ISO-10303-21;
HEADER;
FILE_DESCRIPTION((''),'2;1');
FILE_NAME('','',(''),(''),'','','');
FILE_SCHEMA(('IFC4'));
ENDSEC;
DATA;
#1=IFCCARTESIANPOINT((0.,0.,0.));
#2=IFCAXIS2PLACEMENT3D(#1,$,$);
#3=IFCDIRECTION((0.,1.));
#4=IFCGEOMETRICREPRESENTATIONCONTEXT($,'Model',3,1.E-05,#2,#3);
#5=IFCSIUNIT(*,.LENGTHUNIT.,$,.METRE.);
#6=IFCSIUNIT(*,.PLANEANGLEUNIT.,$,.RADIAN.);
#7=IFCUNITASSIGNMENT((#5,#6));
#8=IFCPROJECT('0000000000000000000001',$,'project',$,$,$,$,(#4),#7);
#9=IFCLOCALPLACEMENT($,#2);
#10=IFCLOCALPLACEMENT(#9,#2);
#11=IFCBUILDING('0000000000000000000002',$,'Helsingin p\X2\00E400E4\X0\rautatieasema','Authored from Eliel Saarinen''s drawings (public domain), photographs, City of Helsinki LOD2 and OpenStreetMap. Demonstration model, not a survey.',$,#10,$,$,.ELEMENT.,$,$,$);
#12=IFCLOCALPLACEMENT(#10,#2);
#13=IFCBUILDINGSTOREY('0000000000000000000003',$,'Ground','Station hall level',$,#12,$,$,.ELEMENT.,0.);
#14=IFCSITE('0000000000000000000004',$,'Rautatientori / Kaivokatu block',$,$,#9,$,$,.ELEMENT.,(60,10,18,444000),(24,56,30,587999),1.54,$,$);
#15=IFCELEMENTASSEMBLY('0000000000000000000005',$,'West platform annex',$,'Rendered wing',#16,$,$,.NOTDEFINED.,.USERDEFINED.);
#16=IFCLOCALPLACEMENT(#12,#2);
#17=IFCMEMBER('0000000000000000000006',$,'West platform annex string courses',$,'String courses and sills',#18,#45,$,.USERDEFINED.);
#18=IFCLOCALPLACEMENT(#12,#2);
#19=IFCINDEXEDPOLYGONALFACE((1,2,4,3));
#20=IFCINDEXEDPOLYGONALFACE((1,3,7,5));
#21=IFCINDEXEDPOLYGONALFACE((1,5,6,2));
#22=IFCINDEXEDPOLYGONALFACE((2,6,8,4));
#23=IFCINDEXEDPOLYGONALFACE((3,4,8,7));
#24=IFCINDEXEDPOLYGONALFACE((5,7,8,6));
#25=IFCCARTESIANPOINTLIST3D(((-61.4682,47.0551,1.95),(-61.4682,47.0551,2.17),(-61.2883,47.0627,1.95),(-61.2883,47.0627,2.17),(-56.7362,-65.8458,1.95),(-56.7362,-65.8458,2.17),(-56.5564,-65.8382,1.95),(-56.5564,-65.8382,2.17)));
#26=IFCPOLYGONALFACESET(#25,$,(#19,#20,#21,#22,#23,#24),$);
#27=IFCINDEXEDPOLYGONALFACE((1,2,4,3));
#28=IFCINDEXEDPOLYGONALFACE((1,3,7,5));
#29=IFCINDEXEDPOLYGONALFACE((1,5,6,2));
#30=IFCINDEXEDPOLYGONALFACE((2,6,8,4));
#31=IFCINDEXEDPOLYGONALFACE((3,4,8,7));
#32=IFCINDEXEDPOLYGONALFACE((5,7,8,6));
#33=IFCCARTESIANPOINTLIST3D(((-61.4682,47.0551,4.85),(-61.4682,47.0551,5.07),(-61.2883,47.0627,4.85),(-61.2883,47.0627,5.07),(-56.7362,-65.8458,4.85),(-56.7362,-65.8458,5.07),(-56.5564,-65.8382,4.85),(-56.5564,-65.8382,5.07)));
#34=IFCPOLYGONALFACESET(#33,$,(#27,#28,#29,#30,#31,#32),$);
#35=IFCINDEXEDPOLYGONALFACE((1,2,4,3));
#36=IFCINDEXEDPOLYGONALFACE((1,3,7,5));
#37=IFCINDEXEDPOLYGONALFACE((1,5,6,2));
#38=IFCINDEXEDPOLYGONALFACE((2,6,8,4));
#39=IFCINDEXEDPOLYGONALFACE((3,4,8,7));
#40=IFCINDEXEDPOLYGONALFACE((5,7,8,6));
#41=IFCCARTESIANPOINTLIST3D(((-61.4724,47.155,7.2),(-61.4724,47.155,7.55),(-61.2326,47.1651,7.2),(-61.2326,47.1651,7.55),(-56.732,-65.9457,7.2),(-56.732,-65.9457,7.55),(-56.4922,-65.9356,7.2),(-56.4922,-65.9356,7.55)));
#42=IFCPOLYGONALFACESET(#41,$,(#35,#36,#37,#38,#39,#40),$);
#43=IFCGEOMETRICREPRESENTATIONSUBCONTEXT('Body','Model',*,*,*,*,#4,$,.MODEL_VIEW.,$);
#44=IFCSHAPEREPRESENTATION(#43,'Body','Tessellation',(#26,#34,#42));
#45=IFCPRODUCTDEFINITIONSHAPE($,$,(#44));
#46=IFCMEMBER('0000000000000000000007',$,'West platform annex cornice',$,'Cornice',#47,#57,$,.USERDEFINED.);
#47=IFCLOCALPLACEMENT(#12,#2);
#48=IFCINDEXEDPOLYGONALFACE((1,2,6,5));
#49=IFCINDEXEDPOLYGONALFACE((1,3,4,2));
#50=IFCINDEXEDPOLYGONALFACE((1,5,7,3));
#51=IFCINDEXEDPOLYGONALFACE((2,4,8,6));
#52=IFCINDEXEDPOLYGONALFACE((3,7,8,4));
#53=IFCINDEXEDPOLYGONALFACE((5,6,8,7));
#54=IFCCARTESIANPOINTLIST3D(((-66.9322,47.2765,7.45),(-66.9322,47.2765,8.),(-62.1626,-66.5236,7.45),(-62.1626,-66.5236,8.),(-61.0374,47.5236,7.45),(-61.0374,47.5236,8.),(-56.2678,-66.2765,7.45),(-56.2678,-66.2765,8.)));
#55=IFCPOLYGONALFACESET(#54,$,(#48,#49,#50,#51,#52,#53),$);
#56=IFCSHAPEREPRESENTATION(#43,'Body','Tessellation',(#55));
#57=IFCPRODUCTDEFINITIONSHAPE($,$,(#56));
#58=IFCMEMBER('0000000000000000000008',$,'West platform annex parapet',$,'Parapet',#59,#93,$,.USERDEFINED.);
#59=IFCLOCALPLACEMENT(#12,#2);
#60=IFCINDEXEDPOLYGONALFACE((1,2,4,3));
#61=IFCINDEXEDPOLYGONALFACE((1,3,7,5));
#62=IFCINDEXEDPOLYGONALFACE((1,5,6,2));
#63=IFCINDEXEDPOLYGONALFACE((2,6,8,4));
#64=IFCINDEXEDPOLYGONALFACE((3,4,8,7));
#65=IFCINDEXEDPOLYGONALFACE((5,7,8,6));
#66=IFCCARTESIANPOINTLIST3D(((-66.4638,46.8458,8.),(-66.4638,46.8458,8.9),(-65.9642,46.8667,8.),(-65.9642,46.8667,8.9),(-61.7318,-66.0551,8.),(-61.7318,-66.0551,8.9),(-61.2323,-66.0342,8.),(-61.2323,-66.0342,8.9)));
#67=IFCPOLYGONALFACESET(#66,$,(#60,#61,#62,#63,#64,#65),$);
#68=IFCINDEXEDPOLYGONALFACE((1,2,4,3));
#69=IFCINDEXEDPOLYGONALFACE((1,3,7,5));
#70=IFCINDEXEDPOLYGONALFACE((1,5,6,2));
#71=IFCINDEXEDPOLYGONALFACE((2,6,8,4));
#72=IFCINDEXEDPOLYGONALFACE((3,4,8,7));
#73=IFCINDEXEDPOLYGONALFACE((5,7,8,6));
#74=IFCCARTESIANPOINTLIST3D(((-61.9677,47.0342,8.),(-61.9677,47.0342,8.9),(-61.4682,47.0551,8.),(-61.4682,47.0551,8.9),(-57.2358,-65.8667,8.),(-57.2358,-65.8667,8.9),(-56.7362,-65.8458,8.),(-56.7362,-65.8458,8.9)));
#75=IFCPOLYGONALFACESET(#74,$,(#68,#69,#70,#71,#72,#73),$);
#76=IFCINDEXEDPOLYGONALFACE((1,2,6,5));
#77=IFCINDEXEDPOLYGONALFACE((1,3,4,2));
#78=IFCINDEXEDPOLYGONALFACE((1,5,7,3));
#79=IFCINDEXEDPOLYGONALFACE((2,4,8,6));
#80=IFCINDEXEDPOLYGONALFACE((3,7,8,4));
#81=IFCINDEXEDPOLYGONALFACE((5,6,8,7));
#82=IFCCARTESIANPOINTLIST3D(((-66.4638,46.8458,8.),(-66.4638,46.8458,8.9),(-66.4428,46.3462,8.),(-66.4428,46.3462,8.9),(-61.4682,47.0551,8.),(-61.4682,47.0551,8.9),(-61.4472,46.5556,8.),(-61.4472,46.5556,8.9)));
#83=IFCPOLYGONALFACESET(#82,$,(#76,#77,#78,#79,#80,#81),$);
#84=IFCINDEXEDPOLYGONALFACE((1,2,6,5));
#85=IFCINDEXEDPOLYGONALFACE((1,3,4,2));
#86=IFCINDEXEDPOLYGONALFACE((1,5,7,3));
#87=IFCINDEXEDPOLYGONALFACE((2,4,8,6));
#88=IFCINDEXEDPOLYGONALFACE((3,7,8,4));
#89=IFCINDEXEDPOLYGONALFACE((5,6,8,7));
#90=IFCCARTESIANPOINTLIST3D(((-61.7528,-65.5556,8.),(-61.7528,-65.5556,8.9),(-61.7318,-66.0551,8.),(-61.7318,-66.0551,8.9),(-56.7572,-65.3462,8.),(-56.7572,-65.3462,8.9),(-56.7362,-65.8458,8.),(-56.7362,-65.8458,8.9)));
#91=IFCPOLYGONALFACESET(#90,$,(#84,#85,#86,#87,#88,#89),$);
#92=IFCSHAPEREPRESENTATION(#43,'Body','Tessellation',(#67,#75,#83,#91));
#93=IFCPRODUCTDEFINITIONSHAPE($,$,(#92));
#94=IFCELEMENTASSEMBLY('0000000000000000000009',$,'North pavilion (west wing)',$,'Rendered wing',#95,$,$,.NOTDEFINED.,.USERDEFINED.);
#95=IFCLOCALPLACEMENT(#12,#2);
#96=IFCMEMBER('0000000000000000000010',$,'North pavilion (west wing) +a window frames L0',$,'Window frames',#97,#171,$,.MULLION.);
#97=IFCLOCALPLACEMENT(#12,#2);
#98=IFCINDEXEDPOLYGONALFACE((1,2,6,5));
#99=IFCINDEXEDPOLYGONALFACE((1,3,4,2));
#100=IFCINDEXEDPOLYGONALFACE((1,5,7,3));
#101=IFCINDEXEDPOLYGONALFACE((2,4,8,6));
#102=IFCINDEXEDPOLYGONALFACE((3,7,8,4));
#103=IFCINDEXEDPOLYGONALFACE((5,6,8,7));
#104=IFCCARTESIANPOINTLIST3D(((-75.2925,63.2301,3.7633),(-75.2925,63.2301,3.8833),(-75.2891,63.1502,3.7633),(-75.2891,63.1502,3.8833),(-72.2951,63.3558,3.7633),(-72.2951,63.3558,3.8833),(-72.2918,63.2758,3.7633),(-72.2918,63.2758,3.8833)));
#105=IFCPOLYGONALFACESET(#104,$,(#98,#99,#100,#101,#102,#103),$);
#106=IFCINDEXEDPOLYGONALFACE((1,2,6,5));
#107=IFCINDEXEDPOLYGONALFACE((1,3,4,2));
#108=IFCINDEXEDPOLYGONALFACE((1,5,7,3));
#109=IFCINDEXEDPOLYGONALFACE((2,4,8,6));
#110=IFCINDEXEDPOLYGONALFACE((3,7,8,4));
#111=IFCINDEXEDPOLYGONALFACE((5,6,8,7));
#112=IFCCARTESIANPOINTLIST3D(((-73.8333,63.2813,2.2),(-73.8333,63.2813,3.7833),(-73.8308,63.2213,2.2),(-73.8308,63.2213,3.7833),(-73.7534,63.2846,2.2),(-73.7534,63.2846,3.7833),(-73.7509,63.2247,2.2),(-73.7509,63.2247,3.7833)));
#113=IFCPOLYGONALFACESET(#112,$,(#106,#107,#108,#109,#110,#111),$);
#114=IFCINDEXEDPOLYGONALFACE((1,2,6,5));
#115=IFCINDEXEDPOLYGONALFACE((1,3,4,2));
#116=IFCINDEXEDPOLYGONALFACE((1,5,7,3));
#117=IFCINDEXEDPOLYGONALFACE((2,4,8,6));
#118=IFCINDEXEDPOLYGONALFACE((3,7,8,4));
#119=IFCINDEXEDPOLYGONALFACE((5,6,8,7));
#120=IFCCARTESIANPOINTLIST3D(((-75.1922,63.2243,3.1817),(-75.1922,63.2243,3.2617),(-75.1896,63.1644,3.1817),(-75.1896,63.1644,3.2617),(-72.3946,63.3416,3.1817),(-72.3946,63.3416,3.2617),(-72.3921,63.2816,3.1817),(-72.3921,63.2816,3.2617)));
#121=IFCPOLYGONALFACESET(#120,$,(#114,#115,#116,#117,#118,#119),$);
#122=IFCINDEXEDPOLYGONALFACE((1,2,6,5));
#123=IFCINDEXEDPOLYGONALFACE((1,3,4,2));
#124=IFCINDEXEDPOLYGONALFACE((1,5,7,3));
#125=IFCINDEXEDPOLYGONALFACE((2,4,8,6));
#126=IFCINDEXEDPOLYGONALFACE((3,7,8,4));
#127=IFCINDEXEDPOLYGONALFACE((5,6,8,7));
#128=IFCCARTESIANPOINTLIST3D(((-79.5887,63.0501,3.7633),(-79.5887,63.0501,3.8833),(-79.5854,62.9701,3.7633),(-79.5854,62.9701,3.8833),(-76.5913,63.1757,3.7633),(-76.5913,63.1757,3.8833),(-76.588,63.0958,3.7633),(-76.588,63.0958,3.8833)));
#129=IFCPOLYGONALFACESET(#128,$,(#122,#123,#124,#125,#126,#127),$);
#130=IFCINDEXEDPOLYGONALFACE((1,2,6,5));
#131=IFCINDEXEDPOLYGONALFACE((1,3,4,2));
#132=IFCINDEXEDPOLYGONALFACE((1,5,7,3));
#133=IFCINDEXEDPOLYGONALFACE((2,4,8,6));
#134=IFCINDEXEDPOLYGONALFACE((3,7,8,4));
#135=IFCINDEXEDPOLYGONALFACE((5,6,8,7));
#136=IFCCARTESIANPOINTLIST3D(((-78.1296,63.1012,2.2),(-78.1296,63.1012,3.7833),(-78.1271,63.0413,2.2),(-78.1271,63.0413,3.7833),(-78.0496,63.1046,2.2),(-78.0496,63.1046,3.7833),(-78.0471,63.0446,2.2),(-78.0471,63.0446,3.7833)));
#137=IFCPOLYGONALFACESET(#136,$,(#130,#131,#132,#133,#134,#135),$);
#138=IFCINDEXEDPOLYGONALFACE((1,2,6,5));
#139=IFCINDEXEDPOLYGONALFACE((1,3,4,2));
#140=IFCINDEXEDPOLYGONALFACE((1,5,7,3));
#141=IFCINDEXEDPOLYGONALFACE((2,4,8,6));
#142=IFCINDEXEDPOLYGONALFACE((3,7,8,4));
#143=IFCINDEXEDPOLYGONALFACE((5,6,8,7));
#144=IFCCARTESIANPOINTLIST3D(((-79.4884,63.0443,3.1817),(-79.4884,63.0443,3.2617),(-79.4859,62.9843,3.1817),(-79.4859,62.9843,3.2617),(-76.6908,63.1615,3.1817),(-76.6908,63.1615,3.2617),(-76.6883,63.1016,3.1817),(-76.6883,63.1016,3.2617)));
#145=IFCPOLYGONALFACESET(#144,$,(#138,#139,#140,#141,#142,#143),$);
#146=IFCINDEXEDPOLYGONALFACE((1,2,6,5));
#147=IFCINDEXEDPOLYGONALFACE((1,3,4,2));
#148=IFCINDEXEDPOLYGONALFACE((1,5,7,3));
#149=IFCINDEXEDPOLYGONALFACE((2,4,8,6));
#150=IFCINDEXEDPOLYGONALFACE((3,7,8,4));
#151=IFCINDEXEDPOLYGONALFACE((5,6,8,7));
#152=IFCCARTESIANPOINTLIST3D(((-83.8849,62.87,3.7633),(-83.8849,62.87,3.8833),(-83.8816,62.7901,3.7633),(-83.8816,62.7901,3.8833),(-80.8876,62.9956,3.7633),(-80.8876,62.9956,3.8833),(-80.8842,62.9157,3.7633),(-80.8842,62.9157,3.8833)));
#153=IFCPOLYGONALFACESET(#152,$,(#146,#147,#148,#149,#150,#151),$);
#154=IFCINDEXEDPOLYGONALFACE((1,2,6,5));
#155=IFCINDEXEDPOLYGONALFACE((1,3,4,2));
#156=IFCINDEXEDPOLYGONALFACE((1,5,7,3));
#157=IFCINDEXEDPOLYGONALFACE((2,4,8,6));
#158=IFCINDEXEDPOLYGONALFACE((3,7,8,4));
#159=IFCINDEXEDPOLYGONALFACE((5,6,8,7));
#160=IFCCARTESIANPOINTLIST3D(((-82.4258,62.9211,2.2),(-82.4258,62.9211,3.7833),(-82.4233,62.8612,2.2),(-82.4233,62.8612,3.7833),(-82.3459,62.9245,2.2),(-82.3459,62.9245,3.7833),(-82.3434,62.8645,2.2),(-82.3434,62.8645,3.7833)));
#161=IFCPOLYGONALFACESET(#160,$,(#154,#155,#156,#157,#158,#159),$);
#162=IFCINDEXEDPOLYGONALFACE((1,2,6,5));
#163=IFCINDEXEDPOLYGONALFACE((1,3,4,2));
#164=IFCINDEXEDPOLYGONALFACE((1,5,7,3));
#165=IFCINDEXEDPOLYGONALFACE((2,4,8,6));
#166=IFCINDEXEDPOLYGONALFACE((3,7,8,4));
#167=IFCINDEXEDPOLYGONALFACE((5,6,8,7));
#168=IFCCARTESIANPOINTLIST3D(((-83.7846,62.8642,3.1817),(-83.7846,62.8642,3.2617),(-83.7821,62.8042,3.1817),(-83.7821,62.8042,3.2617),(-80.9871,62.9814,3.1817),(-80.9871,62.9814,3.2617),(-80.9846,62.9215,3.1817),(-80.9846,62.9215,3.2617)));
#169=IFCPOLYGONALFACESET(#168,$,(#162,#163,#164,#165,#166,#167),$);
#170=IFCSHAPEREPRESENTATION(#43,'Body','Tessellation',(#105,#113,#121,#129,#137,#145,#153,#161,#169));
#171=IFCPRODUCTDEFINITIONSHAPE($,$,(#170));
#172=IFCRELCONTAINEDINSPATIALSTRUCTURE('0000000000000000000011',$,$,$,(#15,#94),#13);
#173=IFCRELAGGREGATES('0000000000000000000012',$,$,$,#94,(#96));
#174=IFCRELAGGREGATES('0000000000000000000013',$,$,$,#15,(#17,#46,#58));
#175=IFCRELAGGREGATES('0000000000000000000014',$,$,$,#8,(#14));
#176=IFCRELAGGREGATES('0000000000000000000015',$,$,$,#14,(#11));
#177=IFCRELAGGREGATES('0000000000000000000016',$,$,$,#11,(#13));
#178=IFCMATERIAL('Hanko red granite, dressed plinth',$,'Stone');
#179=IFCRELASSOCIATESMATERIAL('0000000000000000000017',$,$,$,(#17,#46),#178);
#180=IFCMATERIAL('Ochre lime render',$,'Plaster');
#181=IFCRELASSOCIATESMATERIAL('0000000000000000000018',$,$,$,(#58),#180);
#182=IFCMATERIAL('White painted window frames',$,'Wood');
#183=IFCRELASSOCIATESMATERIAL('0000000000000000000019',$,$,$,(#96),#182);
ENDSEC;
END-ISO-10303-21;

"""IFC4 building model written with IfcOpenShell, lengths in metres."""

from ifc_helpers import new_model, si_unit, direction, frame, frame_2d, origin, place, context, subcontext, project, spatial, rectangle, extrude, material, element, aggregate, save


model = new_model("IFC4")

# Units and contexts
model_context = context("Model", 3, precision=1e-05, world=origin(), true_north=direction((0.0, 1.0)))
body_context = subcontext(model_context, "Body", "Model", "MODEL_VIEW")
ifc_project = project(units=[si_unit("LENGTHUNIT", "METRE"), si_unit("PLANEANGLEUNIT", "RADIAN")], contexts=[model_context])

# Site, building, storey
site_placement = place(None, origin())
site = spatial("IfcSite", under=ifc_project, at=site_placement, Name="Rautatientori / Kaivokatu block", CompositionType="ELEMENT", RefLatitude=(60, 10, 18, 444000), RefLongitude=(24, 56, 30, 587999), RefElevation=1.54)
building_placement = place(site_placement, origin())
building = spatial("IfcBuilding", under=site, at=building_placement, Name="Helsingin päärautatieasema", Description="Authored from Eliel Saarinen's drawings (public domain), photographs, City of Helsinki LOD2 and OpenStreetMap. Demonstration model, not a survey.", CompositionType="ELEMENT")
storey_placement = place(building_placement, origin())
storey = spatial("IfcBuildingStorey", under=building, at=storey_placement, Name="Ground", Description="Station hall level", CompositionType="ELEMENT", Elevation=0.0)

# Element assembly, members
assembly_1_placement = place(building_placement, origin())
assembly_1 = element("IfcElementAssembly", 1, at=assembly_1_placement, inside=storey, Name="West platform annex", ObjectType="Rendered wing", AssemblyPlace="NOTDEFINED", PredefinedType="USERDEFINED")
ifc_material_1 = material(Name="White painted window frames", Category="Wood")
ifc_material_2 = material(Name="Hanko red granite, dressed plinth", Category="Stone")
member_1_placement = place(building_placement, origin())
member_1 = element("IfcMember", 2, at=member_1_placement, material=ifc_material_2, Name="West platform annex string courses", ObjectType="String courses and sills", PredefinedType="USERDEFINED", context=body_context, shape_type="SweptSolid", body=[
    extrude(rectangle(XDim=113.0, YDim=0.18, at=frame_2d((0.0, 0.0), x_axis=(-0.041876, 0.999123))), frame((-59.0123, -9.3915, 1.95)), (0.0, 0.0, 1.0), 0.22),
    extrude(rectangle(XDim=113.0, YDim=0.18, at=frame_2d((0.0, 0.0), x_axis=(-0.041876, 0.999123))), frame((-59.0123, -9.3915, 4.85)), (0.0, 0.0, 1.0), 0.22),
    extrude(rectangle(XDim=113.2, YDim=0.24, at=frame_2d((0.0, 0.0), x_axis=(-0.041876, 0.999123))), frame((-58.9823, -9.3903, 7.2)), (0.0, 0.0, 1.0), 0.35),
])
member_2_placement = place(building_placement, origin())
member_2 = element("IfcMember", 3, at=member_2_placement, material=ifc_material_2, Name="West platform annex cornice", ObjectType="Cornice", PredefinedType="USERDEFINED", context=body_context, shape_type="SweptSolid", body=[
    extrude(rectangle(XDim=113.9, YDim=5.9, at=frame_2d((0.0, 0.0), x_axis=(-0.041876, 0.999123))), frame((-61.6, -9.5, 7.45)), (0.0, 0.0, 1.0), 0.55),
])
ifc_material_3 = material(Name="Ochre lime render", Category="Plaster")
member_3_placement = place(building_placement, origin())
member_3 = element("IfcMember", 4, at=member_3_placement, material=ifc_material_3, Name="West platform annex parapet", ObjectType="Parapet", PredefinedType="USERDEFINED", context=body_context, shape_type="SweptSolid", body=[
    extrude(rectangle(XDim=113.0, YDim=0.5, at=frame_2d((0.0, 0.0), x_axis=(0.041876, -0.999123))), frame((-63.848, -9.5942, 8.0)), (0.0, 0.0, 1.0), 0.9),
    extrude(rectangle(XDim=113.0, YDim=0.5, at=frame_2d((0.0, 0.0), x_axis=(-0.041876, 0.999123))), frame((-59.352, -9.4058, 8.0)), (0.0, 0.0, 1.0), 0.9),
    extrude(rectangle(XDim=5.0, YDim=0.5, at=frame_2d((0.0, 0.0), x_axis=(-0.999123, -0.041876))), frame((-63.9555, 46.7007, 8.0)), (0.0, 0.0, 1.0), 0.9),
    extrude(rectangle(XDim=5.0, YDim=0.5, at=frame_2d((0.0, 0.0), x_axis=(0.999123, 0.041876))), frame((-59.2445, -65.7007, 8.0)), (0.0, 0.0, 1.0), 0.9),
])

# Element assembly, member
assembly_2_placement = place(building_placement, origin())
assembly_2 = element("IfcElementAssembly", 5, at=assembly_2_placement, inside=storey, Name="North pavilion (west wing)", ObjectType="Rendered wing", AssemblyPlace="NOTDEFINED", PredefinedType="USERDEFINED")
member_4_placement = place(building_placement, origin())
member_4 = element("IfcMember", 6, at=member_4_placement, material=ifc_material_1, Name="North pavilion (west wing) +a window frames L0", ObjectType="Window frames", PredefinedType="MULLION", context=body_context, shape_type="SweptSolid", body=[
    extrude(rectangle(XDim=3.0, YDim=0.08, at=frame_2d((0.0, 0.0), x_axis=(-0.999123, -0.041876))), frame((-73.7921, 63.253, 3.7633)), (0.0, 0.0, 1.0), 0.12),
    extrude(rectangle(XDim=0.08, YDim=0.06, at=frame_2d((0.0, 0.0), x_axis=(-0.999123, -0.041876))), frame((-73.7921, 63.253, 2.2)), (0.0, 0.0, 1.0), 1.5833),
    extrude(rectangle(XDim=2.8, YDim=0.06, at=frame_2d((0.0, 0.0), x_axis=(-0.999123, -0.041876))), frame((-73.7921, 63.253, 3.1817)), (0.0, 0.0, 1.0), 0.08),
    extrude(rectangle(XDim=3.0, YDim=0.08, at=frame_2d((0.0, 0.0), x_axis=(-0.999123, -0.041876))), frame((-78.0884, 63.0729, 3.7633)), (0.0, 0.0, 1.0), 0.12),
    extrude(rectangle(XDim=0.08, YDim=0.06, at=frame_2d((0.0, 0.0), x_axis=(-0.999123, -0.041876))), frame((-78.0884, 63.0729, 2.2)), (0.0, 0.0, 1.0), 1.5833),
    extrude(rectangle(XDim=2.8, YDim=0.06, at=frame_2d((0.0, 0.0), x_axis=(-0.999123, -0.041876))), frame((-78.0884, 63.0729, 3.1817)), (0.0, 0.0, 1.0), 0.08),
    extrude(rectangle(XDim=3.0, YDim=0.08, at=frame_2d((0.0, 0.0), x_axis=(-0.999123, -0.041876))), frame((-82.3846, 62.8928, 3.7633)), (0.0, 0.0, 1.0), 0.12),
    extrude(rectangle(XDim=0.08, YDim=0.06, at=frame_2d((0.0, 0.0), x_axis=(-0.999123, -0.041876))), frame((-82.3846, 62.8928, 2.2)), (0.0, 0.0, 1.0), 1.5833),
    extrude(rectangle(XDim=2.8, YDim=0.06, at=frame_2d((0.0, 0.0), x_axis=(-0.999123, -0.041876))), frame((-82.3846, 62.8928, 3.1817)), (0.0, 0.0, 1.0), 0.08),
])

aggregate(assembly_2, [member_4])

aggregate(assembly_1, [member_1, member_2, member_3])

save(model, "model.ifc")
